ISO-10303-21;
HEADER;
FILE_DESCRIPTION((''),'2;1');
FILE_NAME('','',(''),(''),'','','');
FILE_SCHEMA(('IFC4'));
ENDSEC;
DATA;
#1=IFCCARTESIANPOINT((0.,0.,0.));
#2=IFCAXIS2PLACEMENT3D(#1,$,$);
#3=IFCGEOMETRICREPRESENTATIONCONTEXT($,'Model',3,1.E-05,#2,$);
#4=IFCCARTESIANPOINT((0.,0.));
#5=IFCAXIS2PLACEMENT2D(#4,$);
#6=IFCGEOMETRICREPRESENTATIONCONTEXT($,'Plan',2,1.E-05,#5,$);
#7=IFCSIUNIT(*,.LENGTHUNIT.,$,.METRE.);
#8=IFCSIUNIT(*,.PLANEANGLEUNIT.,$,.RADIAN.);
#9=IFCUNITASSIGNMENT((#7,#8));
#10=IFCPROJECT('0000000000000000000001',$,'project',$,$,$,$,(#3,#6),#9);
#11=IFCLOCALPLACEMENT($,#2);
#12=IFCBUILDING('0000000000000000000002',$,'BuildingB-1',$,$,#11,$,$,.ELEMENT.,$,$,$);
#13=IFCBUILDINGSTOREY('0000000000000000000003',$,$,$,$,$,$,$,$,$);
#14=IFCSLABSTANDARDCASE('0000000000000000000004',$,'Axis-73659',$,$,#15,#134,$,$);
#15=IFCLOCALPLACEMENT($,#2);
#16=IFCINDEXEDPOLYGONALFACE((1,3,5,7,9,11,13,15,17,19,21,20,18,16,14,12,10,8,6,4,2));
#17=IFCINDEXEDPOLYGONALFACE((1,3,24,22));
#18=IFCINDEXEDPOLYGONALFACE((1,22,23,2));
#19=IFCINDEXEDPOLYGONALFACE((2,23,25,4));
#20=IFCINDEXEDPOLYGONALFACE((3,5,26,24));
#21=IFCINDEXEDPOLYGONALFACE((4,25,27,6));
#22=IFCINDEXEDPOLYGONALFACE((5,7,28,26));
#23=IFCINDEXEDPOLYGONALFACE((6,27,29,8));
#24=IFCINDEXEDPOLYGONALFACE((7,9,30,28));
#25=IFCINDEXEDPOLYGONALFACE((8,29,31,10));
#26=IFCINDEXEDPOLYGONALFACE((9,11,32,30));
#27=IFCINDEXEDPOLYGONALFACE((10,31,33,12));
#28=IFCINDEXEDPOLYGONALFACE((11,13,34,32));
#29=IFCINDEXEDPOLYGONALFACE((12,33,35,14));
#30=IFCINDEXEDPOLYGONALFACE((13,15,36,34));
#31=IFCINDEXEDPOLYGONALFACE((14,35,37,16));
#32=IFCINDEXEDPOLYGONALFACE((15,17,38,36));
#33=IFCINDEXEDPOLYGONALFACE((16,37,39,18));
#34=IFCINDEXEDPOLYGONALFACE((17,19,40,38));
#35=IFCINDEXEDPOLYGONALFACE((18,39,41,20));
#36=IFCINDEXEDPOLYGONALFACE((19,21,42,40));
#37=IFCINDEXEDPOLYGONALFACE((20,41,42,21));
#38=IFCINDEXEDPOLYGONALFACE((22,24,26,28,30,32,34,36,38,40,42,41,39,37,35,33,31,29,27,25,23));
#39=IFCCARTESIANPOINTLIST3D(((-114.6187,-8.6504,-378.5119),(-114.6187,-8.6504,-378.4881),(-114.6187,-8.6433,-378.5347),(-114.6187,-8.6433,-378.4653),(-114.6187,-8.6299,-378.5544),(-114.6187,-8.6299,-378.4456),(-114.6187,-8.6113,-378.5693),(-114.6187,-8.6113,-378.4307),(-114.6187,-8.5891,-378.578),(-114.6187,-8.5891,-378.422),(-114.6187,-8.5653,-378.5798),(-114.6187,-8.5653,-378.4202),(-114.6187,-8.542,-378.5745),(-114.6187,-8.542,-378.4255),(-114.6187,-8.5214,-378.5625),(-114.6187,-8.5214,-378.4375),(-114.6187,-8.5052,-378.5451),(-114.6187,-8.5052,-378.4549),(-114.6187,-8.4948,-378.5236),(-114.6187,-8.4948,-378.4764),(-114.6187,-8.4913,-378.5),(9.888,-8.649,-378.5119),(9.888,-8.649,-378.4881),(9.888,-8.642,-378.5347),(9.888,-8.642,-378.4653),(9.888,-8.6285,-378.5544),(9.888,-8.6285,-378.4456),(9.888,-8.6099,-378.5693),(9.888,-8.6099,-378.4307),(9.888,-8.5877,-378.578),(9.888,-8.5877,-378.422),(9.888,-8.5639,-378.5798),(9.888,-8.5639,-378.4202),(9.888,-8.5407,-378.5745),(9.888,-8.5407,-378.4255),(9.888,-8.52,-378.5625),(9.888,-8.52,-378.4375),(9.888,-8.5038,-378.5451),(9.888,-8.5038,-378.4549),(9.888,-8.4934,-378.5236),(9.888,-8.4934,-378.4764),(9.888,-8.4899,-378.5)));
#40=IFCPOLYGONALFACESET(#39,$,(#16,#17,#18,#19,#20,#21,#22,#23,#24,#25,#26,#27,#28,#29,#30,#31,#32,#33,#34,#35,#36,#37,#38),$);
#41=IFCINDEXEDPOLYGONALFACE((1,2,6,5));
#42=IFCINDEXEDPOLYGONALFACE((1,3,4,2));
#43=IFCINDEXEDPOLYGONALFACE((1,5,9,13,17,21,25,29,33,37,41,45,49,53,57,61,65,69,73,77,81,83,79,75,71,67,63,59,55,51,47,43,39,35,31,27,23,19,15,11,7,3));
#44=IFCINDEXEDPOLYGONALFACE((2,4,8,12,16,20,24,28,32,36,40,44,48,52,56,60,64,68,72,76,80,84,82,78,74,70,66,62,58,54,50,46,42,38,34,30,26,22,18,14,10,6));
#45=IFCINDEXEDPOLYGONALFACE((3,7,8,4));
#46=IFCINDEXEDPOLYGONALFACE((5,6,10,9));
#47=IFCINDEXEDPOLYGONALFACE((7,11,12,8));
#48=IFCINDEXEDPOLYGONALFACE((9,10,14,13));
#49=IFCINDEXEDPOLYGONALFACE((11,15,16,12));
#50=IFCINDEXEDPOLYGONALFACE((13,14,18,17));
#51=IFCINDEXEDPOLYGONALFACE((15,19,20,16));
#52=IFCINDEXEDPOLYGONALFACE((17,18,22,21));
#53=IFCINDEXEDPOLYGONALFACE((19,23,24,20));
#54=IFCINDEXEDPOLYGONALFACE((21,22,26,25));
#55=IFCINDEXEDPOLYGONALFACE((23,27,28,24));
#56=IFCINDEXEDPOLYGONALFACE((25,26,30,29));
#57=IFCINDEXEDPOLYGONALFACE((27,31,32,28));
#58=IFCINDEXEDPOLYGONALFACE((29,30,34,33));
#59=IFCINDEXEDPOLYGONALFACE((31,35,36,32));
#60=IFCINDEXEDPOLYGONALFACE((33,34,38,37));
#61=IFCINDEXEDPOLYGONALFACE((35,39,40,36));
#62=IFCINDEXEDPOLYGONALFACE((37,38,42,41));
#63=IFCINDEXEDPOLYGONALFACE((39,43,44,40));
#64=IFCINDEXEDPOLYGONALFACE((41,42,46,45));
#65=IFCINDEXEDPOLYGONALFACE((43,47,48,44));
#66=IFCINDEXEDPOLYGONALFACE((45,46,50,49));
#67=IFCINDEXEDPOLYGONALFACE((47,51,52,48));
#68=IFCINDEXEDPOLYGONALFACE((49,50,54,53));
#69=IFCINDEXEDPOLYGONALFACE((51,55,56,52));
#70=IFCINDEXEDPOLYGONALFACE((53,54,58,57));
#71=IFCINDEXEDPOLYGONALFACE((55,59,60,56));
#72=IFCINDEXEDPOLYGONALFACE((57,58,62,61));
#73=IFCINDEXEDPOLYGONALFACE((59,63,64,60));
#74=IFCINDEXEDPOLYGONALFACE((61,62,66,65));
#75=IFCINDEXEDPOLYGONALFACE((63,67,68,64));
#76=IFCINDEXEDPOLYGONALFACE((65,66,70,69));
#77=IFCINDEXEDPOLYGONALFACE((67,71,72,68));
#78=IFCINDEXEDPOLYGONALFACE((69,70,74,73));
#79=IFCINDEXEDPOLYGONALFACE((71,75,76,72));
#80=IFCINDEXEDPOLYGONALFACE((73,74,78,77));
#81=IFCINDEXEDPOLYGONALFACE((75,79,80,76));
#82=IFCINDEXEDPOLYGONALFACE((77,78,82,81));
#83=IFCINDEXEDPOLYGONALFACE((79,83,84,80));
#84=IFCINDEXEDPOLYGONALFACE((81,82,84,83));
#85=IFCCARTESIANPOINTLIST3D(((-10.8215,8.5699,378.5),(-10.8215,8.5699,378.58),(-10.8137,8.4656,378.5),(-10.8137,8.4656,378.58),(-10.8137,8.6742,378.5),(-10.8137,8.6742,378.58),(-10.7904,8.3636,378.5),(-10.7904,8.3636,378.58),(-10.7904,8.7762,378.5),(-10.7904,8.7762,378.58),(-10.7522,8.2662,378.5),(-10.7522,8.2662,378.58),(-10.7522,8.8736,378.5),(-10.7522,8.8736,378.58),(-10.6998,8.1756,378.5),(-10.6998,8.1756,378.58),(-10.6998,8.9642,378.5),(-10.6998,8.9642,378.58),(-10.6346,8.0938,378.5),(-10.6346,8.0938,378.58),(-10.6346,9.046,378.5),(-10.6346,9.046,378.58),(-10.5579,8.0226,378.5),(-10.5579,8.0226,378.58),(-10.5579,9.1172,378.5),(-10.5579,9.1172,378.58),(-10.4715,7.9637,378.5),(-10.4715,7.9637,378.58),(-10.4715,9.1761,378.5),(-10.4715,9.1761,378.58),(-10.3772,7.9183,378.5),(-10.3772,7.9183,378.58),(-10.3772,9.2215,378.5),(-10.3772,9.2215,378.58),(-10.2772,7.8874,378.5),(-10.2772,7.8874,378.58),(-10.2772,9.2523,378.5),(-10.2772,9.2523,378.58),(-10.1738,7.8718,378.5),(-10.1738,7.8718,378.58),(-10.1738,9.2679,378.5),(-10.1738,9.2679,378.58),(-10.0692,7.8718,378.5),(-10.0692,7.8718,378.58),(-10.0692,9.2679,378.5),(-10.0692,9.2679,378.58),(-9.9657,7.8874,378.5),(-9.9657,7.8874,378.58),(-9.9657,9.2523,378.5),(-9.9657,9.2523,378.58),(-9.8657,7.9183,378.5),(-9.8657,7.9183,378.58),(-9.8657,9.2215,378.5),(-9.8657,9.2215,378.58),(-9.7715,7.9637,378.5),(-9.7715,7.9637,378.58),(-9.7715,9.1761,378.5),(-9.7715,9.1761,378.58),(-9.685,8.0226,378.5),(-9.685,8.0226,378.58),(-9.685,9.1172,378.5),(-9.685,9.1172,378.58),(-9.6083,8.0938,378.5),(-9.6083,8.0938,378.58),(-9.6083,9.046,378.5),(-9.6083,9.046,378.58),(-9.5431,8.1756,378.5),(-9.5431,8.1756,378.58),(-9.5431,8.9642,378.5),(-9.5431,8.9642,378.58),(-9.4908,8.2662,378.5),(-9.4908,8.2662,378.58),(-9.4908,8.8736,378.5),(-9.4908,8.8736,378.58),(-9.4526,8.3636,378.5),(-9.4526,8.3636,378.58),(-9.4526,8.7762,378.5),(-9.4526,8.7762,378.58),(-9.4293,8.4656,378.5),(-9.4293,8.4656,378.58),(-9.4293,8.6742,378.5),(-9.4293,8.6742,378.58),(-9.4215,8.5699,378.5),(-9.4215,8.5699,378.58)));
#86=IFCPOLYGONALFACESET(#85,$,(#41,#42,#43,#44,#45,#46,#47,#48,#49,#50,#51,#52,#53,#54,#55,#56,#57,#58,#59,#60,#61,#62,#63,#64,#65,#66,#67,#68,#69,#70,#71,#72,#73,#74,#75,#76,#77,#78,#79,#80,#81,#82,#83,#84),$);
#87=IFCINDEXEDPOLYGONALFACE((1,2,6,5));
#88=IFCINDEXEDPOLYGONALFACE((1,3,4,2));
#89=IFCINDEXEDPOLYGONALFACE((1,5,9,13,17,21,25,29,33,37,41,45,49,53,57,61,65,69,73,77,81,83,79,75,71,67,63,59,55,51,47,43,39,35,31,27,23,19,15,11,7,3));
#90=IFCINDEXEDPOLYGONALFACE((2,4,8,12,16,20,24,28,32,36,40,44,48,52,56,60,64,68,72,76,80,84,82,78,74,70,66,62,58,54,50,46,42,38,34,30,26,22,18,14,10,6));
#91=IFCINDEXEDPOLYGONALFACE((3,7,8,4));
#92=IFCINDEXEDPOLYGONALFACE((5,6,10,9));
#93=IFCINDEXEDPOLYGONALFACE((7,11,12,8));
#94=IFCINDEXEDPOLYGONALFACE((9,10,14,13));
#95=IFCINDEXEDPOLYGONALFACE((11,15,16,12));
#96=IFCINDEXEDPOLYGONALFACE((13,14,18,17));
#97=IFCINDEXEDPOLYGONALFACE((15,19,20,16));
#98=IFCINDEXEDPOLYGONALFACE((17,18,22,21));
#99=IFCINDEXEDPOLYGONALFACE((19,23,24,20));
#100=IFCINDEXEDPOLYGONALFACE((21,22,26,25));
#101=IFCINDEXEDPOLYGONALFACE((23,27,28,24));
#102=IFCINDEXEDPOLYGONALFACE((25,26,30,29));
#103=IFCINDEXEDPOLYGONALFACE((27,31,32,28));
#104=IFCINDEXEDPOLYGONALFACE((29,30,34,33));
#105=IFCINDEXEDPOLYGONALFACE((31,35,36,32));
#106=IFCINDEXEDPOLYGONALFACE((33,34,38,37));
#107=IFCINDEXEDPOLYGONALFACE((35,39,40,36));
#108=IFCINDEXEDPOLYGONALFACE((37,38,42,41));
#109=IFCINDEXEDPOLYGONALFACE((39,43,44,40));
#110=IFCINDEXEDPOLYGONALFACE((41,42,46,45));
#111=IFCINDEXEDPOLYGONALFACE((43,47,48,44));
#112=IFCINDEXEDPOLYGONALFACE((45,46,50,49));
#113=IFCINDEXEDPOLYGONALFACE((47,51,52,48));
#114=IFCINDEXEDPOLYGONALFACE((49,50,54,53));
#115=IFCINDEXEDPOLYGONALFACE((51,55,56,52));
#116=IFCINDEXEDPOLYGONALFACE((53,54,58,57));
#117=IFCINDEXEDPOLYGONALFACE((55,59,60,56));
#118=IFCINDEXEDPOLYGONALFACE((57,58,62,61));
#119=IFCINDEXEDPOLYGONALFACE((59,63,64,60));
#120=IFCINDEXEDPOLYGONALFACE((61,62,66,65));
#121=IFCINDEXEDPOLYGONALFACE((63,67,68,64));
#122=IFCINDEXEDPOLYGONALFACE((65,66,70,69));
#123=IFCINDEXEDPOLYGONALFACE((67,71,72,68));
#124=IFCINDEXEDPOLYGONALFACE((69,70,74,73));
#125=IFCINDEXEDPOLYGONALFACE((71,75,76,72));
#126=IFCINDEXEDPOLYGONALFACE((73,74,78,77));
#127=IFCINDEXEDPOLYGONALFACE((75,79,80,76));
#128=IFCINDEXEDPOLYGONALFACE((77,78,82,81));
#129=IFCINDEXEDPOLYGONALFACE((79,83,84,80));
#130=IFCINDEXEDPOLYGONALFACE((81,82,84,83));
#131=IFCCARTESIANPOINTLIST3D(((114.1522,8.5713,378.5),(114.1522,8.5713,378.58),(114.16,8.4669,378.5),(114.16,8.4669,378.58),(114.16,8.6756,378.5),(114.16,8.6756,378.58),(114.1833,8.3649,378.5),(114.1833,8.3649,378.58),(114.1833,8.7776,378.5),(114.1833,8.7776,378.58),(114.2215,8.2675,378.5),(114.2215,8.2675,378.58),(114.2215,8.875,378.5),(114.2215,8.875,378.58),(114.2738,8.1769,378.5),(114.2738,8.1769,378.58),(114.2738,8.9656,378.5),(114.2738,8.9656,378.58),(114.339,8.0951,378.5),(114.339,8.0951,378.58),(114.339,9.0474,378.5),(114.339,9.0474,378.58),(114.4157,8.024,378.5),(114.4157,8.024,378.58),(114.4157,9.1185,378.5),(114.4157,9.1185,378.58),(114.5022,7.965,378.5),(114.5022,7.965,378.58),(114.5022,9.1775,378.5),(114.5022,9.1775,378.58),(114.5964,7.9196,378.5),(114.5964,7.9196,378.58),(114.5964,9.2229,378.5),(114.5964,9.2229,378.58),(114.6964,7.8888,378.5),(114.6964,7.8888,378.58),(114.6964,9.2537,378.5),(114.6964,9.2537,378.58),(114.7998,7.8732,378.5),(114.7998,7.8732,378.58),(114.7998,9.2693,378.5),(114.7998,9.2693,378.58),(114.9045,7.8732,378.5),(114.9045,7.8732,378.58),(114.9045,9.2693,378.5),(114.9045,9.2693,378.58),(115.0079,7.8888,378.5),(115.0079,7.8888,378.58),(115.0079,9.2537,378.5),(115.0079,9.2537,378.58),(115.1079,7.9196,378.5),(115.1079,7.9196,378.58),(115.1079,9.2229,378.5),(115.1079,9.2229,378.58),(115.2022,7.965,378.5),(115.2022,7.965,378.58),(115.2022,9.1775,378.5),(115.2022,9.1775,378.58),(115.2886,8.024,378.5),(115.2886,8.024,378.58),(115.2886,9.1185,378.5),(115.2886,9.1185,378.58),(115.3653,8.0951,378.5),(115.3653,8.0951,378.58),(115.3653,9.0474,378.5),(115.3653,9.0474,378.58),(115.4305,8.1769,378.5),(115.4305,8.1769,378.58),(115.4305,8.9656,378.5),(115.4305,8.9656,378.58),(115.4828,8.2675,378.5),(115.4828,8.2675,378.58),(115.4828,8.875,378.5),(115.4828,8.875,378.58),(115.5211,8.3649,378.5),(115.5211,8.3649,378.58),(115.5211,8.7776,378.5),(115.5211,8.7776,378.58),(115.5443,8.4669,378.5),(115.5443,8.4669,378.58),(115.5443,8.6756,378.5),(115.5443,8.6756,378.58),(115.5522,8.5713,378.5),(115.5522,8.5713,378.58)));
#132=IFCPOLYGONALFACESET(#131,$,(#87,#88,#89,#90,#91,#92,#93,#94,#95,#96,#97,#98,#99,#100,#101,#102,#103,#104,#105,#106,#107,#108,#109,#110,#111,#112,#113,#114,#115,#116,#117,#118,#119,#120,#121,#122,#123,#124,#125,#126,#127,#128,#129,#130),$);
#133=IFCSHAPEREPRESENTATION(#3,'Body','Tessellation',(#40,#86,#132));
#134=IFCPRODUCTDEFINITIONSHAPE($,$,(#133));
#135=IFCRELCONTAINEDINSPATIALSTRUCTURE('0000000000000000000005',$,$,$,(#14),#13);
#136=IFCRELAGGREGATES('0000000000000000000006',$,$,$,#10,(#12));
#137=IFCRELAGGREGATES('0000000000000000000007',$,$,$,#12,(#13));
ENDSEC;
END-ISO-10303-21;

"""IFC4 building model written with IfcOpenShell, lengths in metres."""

from ifc_helpers import new_model, entity, si_unit, frame, origin, origin_2d, place, context, project, spatial, circle, extrude, element, save


model = new_model("IFC4")

# Units and contexts
model_context = context("Model", 3, precision=1e-05, world=origin())
plan_context = context("Plan", 2, precision=1e-05, world=origin_2d())
ifc_project = project(units=[si_unit("LENGTHUNIT", "METRE"), si_unit("PLANEANGLEUNIT", "RADIAN")], contexts=[model_context, plan_context])

# Building, storey
building_placement = place(None, origin())
building = spatial("IfcBuilding", under=ifc_project, at=building_placement, Name="BuildingB-1", CompositionType="ELEMENT")
storey = spatial("IfcBuildingStorey", under=building)

# Slab
element("IfcSlabStandardCase", 1, inside=storey, Name="Axis-73659", context=model_context, shape_type="AdvancedSweptSolid", body=[
    entity("IfcSurfaceCurveSweptAreaSolid", entity("IfcCircleProfileDef", "AREA", None, None, 0.08), None, entity("IfcPolyline", [entity("IfcCartesianPoint", [-9.888, 8.5699, 378.5]), entity("IfcCartesianPoint", [114.6187, 8.5713, 378.5])]), None, None, entity("IfcPlane", entity("IfcAxis2Placement3D", entity("IfcCartesianPoint", [-9.888, 8.5699, 378.5]), entity("IfcDirection", [0.0, 0.0, 1.0]), entity("IfcDirection", [1.0, 0.0, 0.0])))),
    extrude(circle(Radius=0.7), frame((-10.1215, 8.5699, 378.5)), (0.0, 0.0, 1.0), 0.08),
    extrude(circle(Radius=0.7), frame((114.8522, 8.5713, 378.5)), (0.0, 0.0, 1.0), 0.08),
])

save(model, "model.ifc")
